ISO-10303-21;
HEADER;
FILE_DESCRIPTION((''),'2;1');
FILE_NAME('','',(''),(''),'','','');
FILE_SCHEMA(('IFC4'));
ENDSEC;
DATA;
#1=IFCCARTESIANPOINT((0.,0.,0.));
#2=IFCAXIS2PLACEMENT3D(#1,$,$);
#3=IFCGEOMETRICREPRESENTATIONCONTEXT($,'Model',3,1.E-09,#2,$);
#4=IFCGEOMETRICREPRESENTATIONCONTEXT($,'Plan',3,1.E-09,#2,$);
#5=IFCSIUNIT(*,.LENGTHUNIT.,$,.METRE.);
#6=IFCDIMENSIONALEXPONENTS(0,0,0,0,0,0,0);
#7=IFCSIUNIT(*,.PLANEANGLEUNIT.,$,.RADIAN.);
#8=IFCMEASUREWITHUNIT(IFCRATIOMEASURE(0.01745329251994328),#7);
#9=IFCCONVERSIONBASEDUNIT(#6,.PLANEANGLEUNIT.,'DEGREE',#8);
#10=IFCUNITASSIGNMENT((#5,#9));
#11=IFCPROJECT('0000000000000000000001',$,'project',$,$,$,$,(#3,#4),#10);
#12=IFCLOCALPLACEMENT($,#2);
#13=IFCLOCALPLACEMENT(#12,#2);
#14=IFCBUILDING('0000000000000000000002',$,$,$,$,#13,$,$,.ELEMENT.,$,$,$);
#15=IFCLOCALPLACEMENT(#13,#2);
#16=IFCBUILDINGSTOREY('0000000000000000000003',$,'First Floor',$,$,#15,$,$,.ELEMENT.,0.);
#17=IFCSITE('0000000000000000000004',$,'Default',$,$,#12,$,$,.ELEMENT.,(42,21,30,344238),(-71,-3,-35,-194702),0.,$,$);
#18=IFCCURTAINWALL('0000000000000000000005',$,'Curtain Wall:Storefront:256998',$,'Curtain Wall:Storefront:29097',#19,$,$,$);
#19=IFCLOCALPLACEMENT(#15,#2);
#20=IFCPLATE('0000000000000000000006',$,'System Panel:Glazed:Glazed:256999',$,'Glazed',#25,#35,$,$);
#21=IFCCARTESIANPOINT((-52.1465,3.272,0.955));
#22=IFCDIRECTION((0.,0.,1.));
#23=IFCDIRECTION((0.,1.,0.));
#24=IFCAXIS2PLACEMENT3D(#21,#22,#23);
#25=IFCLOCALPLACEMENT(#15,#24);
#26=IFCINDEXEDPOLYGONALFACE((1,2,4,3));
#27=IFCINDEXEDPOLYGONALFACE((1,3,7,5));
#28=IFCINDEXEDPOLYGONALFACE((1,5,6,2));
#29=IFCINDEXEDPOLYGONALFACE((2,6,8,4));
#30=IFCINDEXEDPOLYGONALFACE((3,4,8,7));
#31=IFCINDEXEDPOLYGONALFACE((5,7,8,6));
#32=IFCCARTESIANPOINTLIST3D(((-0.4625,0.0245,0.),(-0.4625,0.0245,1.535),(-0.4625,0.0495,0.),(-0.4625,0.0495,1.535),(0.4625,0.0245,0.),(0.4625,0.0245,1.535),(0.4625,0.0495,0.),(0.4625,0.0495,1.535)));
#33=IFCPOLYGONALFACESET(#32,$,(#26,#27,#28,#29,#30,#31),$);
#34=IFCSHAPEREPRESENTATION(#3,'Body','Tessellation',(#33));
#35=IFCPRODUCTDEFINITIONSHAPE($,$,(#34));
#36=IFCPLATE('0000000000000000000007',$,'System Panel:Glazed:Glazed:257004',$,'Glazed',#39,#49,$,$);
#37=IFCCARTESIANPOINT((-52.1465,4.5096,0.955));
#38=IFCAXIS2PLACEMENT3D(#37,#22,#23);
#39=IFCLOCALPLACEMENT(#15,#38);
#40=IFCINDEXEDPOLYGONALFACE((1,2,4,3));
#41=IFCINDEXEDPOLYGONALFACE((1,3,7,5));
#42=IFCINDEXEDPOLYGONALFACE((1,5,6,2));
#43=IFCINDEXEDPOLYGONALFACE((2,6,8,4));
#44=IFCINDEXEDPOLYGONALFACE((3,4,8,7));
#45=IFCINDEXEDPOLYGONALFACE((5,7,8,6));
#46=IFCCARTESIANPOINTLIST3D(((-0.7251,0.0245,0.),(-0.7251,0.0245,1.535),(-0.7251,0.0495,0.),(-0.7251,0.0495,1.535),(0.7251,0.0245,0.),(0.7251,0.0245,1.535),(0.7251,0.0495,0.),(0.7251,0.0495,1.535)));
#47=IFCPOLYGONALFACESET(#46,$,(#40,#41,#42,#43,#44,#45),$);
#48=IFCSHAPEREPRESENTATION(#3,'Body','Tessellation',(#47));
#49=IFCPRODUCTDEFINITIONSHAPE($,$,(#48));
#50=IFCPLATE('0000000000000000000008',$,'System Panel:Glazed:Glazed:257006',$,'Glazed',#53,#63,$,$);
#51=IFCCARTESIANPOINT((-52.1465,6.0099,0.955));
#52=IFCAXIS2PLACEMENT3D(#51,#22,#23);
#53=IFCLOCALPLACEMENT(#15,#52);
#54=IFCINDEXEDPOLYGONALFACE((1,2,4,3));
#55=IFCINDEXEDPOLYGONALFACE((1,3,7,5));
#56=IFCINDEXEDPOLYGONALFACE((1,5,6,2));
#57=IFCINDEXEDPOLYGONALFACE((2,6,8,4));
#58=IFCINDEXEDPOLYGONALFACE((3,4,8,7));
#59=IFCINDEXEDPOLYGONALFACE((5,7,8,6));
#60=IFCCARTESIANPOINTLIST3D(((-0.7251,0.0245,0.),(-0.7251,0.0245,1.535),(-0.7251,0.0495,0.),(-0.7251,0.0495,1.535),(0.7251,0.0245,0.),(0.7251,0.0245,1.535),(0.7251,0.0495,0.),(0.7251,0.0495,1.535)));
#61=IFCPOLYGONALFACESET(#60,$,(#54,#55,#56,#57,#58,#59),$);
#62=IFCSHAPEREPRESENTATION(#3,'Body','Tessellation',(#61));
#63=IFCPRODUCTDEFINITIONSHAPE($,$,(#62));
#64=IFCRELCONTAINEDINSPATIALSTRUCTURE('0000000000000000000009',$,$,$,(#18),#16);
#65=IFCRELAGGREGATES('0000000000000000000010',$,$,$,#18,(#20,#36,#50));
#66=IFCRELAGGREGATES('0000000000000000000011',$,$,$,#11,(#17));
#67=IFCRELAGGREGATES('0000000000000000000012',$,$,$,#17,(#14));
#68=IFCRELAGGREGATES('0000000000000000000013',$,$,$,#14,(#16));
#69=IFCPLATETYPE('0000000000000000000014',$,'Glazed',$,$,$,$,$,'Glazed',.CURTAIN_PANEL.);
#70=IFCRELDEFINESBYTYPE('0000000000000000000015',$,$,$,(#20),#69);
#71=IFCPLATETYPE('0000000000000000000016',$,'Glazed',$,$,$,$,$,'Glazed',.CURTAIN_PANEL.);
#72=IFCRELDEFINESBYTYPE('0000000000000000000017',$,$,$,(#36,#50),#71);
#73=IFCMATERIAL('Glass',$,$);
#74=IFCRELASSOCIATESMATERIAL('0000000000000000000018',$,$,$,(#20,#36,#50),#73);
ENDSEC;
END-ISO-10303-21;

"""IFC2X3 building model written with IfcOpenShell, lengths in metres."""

from ifc_helpers import new_model, entity, si_unit, converted_unit, frame, origin, origin_2d_with_axis, place, context, project, spatial, rectangle, extrude, source, transform, mapped, material, type_object, type_shapes, element, aggregate, save


model = new_model("IFC2X3")

# Units and contexts
model_context = context("Model", 3, precision=1e-09, world=origin())
plan_context = context("Plan", 3, precision=1e-09, world=origin())
ifc_project = project(units=[si_unit("LENGTHUNIT", "METRE"), converted_unit("PLANEANGLEUNIT", "DEGREE", entity("IfcRatioMeasure", 0.01745329251994328), si_unit("PLANEANGLEUNIT", "RADIAN"), dimensions=[0, 0, 0, 0, 0, 0, 0])], contexts=[model_context, plan_context])

# Site, building, storey
site_placement = place(None, origin())
site = spatial("IfcSite", under=ifc_project, at=site_placement, Name="Default", CompositionType="ELEMENT", RefLatitude=(42, 21, 30, 344238), RefLongitude=(-71, -3, -35, -194702), RefElevation=0.0)
building_placement = place(site_placement, origin())
building = spatial("IfcBuilding", under=site, at=building_placement, CompositionType="ELEMENT")
storey_placement = place(building_placement, origin())
storey = spatial("IfcBuildingStorey", under=building, at=storey_placement, Name="First Floor", CompositionType="ELEMENT", Elevation=0.0)

# Curtain wall, plates
curtain_wall_placement = place(storey_placement, origin())
curtain_wall = element("IfcCurtainWall", 1, at=curtain_wall_placement, inside=storey, Name="Curtain Wall:Storefront:256998", ObjectType="Curtain Wall:Storefront:29097")
ifc_material_1 = material(Name="Glass")
plate_type_1 = type_object("IfcPlateType", Name="Glazed", ElementType="Glazed", PredefinedType="CURTAIN_PANEL")
shared_shape_1 = source(origin(), model_context, "Body", "SweptSolid", [
    extrude(rectangle(XDim=0.025, YDim=0.925, at=origin_2d_with_axis()), frame((0.0, 0.037, 0.0), z_axis=(0.0, 0.0, 1.0), x_axis=(0.0, 1.0, 0.0)), (0.0, 0.0, 1.0), 1.535),
])
type_shapes(plate_type_1, [shared_shape_1])
plate_1_placement = place(storey_placement, frame((-52.1465, 3.272, 0.955), z_axis=(0.0, 0.0, 1.0), x_axis=(0.0, 1.0, 0.0)))
plate_1 = element("IfcPlate", 2, at=plate_1_placement, type_object=plate_type_1, material=ifc_material_1, Name="System Panel:Glazed:Glazed:256999", ObjectType="Glazed", context=model_context, shape_type="MappedRepresentation", body=[
    mapped(shared_shape_1, transform((0.0, 0.0, 0.0), scale=1.0)),
])
plate_type_2 = type_object("IfcPlateType", Name="Glazed", ElementType="Glazed", PredefinedType="CURTAIN_PANEL")
shared_shape_2 = source(origin(), model_context, "Body", "SweptSolid", [
    extrude(rectangle(XDim=0.025, YDim=1.4503, at=origin_2d_with_axis()), frame((0.0, 0.037, 0.0), z_axis=(0.0, 0.0, 1.0), x_axis=(0.0, 1.0, 0.0)), (0.0, 0.0, 1.0), 1.535),
])
type_shapes(plate_type_2, [shared_shape_2])
plate_2_placement = place(storey_placement, frame((-52.1465, 4.5096, 0.955), z_axis=(0.0, 0.0, 1.0), x_axis=(0.0, 1.0, 0.0)))
plate_2 = element("IfcPlate", 3, at=plate_2_placement, type_object=plate_type_2, material=ifc_material_1, Name="System Panel:Glazed:Glazed:257004", ObjectType="Glazed", context=model_context, shape_type="MappedRepresentation", body=[
    mapped(shared_shape_2, transform((0.0, 0.0, 0.0), scale=1.0)),
])
plate_3_placement = place(storey_placement, frame((-52.1465, 6.0099, 0.955), z_axis=(0.0, 0.0, 1.0), x_axis=(0.0, 1.0, 0.0)))
plate_3 = element("IfcPlate", 4, at=plate_3_placement, type_object=plate_type_2, material=ifc_material_1, Name="System Panel:Glazed:Glazed:257006", ObjectType="Glazed", context=model_context, shape_type="MappedRepresentation", body=[
    mapped(shared_shape_2, transform((0.0, 0.0, 0.0), scale=1.0)),
])
aggregate(curtain_wall, [plate_1, plate_2, plate_3])

save(model, "model.ifc")
